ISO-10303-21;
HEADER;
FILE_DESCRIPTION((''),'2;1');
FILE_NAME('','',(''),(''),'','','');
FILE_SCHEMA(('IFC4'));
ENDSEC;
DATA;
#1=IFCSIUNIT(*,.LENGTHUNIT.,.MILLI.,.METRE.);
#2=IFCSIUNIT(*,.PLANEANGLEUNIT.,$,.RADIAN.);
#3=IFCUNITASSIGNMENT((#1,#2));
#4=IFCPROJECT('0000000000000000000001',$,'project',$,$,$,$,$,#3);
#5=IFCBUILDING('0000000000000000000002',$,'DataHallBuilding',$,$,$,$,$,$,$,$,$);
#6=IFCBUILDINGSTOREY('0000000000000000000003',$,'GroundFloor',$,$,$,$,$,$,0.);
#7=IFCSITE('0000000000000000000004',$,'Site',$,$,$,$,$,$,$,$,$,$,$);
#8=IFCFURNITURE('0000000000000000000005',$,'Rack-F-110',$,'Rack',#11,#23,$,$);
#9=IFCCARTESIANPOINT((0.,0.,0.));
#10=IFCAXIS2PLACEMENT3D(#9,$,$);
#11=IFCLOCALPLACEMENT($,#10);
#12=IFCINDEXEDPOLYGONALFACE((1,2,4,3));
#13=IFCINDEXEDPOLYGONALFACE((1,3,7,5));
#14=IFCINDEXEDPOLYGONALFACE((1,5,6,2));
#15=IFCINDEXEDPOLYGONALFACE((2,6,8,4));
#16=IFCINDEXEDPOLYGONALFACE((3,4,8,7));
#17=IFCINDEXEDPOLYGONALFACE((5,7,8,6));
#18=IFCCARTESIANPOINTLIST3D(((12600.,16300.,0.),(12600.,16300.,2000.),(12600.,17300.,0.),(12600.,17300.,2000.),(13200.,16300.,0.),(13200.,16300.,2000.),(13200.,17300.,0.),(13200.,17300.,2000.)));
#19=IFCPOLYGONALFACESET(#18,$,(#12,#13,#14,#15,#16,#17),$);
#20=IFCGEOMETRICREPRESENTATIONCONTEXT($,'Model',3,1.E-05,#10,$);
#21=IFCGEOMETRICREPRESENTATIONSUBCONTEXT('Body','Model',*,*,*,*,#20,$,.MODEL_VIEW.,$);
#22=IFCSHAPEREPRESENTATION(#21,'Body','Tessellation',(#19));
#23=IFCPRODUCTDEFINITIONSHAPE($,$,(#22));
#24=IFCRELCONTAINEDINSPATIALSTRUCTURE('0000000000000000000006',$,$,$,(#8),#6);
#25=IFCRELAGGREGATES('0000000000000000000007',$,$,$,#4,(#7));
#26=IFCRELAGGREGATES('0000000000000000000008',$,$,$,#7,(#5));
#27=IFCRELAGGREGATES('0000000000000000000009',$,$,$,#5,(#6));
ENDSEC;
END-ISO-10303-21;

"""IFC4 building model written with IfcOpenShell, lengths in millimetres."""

from ifc_helpers import new_model, si_unit, frame, origin, place, context, subcontext, project, spatial, rectangle, extrude, element, save


model = new_model("IFC4")

# Units and contexts
model_context = context("Model", 3, precision=1e-05, world=origin())
body_context = subcontext(model_context, "Body", "Model", "MODEL_VIEW")
ifc_project = project(units=[si_unit("LENGTHUNIT", "METRE", prefix="MILLI"), si_unit("PLANEANGLEUNIT", "RADIAN")])

# Site, building, storey
site = spatial("IfcSite", under=ifc_project, Name="Site")
building = spatial("IfcBuilding", under=site, Name="DataHallBuilding")
storey = spatial("IfcBuildingStorey", under=building, Name="GroundFloor", Elevation=0.0)

# Furniture
furniture_1_placement = place(None, origin())
element("IfcFurniture", 1, at=furniture_1_placement, inside=storey, Name="Rack-F-110", ObjectType="Rack", context=body_context, shape_type="SweptSolid", body=[
    extrude(rectangle(XDim=600.0, YDim=1000.0), frame((12900.0, 16800.0, 0.0), z_axis=(0.0, 0.0, 1.0), x_axis=(1.0, 0.0, 0.0)), (0.0, 0.0, 1.0), 2000.0),
])

save(model, "model.ifc")
